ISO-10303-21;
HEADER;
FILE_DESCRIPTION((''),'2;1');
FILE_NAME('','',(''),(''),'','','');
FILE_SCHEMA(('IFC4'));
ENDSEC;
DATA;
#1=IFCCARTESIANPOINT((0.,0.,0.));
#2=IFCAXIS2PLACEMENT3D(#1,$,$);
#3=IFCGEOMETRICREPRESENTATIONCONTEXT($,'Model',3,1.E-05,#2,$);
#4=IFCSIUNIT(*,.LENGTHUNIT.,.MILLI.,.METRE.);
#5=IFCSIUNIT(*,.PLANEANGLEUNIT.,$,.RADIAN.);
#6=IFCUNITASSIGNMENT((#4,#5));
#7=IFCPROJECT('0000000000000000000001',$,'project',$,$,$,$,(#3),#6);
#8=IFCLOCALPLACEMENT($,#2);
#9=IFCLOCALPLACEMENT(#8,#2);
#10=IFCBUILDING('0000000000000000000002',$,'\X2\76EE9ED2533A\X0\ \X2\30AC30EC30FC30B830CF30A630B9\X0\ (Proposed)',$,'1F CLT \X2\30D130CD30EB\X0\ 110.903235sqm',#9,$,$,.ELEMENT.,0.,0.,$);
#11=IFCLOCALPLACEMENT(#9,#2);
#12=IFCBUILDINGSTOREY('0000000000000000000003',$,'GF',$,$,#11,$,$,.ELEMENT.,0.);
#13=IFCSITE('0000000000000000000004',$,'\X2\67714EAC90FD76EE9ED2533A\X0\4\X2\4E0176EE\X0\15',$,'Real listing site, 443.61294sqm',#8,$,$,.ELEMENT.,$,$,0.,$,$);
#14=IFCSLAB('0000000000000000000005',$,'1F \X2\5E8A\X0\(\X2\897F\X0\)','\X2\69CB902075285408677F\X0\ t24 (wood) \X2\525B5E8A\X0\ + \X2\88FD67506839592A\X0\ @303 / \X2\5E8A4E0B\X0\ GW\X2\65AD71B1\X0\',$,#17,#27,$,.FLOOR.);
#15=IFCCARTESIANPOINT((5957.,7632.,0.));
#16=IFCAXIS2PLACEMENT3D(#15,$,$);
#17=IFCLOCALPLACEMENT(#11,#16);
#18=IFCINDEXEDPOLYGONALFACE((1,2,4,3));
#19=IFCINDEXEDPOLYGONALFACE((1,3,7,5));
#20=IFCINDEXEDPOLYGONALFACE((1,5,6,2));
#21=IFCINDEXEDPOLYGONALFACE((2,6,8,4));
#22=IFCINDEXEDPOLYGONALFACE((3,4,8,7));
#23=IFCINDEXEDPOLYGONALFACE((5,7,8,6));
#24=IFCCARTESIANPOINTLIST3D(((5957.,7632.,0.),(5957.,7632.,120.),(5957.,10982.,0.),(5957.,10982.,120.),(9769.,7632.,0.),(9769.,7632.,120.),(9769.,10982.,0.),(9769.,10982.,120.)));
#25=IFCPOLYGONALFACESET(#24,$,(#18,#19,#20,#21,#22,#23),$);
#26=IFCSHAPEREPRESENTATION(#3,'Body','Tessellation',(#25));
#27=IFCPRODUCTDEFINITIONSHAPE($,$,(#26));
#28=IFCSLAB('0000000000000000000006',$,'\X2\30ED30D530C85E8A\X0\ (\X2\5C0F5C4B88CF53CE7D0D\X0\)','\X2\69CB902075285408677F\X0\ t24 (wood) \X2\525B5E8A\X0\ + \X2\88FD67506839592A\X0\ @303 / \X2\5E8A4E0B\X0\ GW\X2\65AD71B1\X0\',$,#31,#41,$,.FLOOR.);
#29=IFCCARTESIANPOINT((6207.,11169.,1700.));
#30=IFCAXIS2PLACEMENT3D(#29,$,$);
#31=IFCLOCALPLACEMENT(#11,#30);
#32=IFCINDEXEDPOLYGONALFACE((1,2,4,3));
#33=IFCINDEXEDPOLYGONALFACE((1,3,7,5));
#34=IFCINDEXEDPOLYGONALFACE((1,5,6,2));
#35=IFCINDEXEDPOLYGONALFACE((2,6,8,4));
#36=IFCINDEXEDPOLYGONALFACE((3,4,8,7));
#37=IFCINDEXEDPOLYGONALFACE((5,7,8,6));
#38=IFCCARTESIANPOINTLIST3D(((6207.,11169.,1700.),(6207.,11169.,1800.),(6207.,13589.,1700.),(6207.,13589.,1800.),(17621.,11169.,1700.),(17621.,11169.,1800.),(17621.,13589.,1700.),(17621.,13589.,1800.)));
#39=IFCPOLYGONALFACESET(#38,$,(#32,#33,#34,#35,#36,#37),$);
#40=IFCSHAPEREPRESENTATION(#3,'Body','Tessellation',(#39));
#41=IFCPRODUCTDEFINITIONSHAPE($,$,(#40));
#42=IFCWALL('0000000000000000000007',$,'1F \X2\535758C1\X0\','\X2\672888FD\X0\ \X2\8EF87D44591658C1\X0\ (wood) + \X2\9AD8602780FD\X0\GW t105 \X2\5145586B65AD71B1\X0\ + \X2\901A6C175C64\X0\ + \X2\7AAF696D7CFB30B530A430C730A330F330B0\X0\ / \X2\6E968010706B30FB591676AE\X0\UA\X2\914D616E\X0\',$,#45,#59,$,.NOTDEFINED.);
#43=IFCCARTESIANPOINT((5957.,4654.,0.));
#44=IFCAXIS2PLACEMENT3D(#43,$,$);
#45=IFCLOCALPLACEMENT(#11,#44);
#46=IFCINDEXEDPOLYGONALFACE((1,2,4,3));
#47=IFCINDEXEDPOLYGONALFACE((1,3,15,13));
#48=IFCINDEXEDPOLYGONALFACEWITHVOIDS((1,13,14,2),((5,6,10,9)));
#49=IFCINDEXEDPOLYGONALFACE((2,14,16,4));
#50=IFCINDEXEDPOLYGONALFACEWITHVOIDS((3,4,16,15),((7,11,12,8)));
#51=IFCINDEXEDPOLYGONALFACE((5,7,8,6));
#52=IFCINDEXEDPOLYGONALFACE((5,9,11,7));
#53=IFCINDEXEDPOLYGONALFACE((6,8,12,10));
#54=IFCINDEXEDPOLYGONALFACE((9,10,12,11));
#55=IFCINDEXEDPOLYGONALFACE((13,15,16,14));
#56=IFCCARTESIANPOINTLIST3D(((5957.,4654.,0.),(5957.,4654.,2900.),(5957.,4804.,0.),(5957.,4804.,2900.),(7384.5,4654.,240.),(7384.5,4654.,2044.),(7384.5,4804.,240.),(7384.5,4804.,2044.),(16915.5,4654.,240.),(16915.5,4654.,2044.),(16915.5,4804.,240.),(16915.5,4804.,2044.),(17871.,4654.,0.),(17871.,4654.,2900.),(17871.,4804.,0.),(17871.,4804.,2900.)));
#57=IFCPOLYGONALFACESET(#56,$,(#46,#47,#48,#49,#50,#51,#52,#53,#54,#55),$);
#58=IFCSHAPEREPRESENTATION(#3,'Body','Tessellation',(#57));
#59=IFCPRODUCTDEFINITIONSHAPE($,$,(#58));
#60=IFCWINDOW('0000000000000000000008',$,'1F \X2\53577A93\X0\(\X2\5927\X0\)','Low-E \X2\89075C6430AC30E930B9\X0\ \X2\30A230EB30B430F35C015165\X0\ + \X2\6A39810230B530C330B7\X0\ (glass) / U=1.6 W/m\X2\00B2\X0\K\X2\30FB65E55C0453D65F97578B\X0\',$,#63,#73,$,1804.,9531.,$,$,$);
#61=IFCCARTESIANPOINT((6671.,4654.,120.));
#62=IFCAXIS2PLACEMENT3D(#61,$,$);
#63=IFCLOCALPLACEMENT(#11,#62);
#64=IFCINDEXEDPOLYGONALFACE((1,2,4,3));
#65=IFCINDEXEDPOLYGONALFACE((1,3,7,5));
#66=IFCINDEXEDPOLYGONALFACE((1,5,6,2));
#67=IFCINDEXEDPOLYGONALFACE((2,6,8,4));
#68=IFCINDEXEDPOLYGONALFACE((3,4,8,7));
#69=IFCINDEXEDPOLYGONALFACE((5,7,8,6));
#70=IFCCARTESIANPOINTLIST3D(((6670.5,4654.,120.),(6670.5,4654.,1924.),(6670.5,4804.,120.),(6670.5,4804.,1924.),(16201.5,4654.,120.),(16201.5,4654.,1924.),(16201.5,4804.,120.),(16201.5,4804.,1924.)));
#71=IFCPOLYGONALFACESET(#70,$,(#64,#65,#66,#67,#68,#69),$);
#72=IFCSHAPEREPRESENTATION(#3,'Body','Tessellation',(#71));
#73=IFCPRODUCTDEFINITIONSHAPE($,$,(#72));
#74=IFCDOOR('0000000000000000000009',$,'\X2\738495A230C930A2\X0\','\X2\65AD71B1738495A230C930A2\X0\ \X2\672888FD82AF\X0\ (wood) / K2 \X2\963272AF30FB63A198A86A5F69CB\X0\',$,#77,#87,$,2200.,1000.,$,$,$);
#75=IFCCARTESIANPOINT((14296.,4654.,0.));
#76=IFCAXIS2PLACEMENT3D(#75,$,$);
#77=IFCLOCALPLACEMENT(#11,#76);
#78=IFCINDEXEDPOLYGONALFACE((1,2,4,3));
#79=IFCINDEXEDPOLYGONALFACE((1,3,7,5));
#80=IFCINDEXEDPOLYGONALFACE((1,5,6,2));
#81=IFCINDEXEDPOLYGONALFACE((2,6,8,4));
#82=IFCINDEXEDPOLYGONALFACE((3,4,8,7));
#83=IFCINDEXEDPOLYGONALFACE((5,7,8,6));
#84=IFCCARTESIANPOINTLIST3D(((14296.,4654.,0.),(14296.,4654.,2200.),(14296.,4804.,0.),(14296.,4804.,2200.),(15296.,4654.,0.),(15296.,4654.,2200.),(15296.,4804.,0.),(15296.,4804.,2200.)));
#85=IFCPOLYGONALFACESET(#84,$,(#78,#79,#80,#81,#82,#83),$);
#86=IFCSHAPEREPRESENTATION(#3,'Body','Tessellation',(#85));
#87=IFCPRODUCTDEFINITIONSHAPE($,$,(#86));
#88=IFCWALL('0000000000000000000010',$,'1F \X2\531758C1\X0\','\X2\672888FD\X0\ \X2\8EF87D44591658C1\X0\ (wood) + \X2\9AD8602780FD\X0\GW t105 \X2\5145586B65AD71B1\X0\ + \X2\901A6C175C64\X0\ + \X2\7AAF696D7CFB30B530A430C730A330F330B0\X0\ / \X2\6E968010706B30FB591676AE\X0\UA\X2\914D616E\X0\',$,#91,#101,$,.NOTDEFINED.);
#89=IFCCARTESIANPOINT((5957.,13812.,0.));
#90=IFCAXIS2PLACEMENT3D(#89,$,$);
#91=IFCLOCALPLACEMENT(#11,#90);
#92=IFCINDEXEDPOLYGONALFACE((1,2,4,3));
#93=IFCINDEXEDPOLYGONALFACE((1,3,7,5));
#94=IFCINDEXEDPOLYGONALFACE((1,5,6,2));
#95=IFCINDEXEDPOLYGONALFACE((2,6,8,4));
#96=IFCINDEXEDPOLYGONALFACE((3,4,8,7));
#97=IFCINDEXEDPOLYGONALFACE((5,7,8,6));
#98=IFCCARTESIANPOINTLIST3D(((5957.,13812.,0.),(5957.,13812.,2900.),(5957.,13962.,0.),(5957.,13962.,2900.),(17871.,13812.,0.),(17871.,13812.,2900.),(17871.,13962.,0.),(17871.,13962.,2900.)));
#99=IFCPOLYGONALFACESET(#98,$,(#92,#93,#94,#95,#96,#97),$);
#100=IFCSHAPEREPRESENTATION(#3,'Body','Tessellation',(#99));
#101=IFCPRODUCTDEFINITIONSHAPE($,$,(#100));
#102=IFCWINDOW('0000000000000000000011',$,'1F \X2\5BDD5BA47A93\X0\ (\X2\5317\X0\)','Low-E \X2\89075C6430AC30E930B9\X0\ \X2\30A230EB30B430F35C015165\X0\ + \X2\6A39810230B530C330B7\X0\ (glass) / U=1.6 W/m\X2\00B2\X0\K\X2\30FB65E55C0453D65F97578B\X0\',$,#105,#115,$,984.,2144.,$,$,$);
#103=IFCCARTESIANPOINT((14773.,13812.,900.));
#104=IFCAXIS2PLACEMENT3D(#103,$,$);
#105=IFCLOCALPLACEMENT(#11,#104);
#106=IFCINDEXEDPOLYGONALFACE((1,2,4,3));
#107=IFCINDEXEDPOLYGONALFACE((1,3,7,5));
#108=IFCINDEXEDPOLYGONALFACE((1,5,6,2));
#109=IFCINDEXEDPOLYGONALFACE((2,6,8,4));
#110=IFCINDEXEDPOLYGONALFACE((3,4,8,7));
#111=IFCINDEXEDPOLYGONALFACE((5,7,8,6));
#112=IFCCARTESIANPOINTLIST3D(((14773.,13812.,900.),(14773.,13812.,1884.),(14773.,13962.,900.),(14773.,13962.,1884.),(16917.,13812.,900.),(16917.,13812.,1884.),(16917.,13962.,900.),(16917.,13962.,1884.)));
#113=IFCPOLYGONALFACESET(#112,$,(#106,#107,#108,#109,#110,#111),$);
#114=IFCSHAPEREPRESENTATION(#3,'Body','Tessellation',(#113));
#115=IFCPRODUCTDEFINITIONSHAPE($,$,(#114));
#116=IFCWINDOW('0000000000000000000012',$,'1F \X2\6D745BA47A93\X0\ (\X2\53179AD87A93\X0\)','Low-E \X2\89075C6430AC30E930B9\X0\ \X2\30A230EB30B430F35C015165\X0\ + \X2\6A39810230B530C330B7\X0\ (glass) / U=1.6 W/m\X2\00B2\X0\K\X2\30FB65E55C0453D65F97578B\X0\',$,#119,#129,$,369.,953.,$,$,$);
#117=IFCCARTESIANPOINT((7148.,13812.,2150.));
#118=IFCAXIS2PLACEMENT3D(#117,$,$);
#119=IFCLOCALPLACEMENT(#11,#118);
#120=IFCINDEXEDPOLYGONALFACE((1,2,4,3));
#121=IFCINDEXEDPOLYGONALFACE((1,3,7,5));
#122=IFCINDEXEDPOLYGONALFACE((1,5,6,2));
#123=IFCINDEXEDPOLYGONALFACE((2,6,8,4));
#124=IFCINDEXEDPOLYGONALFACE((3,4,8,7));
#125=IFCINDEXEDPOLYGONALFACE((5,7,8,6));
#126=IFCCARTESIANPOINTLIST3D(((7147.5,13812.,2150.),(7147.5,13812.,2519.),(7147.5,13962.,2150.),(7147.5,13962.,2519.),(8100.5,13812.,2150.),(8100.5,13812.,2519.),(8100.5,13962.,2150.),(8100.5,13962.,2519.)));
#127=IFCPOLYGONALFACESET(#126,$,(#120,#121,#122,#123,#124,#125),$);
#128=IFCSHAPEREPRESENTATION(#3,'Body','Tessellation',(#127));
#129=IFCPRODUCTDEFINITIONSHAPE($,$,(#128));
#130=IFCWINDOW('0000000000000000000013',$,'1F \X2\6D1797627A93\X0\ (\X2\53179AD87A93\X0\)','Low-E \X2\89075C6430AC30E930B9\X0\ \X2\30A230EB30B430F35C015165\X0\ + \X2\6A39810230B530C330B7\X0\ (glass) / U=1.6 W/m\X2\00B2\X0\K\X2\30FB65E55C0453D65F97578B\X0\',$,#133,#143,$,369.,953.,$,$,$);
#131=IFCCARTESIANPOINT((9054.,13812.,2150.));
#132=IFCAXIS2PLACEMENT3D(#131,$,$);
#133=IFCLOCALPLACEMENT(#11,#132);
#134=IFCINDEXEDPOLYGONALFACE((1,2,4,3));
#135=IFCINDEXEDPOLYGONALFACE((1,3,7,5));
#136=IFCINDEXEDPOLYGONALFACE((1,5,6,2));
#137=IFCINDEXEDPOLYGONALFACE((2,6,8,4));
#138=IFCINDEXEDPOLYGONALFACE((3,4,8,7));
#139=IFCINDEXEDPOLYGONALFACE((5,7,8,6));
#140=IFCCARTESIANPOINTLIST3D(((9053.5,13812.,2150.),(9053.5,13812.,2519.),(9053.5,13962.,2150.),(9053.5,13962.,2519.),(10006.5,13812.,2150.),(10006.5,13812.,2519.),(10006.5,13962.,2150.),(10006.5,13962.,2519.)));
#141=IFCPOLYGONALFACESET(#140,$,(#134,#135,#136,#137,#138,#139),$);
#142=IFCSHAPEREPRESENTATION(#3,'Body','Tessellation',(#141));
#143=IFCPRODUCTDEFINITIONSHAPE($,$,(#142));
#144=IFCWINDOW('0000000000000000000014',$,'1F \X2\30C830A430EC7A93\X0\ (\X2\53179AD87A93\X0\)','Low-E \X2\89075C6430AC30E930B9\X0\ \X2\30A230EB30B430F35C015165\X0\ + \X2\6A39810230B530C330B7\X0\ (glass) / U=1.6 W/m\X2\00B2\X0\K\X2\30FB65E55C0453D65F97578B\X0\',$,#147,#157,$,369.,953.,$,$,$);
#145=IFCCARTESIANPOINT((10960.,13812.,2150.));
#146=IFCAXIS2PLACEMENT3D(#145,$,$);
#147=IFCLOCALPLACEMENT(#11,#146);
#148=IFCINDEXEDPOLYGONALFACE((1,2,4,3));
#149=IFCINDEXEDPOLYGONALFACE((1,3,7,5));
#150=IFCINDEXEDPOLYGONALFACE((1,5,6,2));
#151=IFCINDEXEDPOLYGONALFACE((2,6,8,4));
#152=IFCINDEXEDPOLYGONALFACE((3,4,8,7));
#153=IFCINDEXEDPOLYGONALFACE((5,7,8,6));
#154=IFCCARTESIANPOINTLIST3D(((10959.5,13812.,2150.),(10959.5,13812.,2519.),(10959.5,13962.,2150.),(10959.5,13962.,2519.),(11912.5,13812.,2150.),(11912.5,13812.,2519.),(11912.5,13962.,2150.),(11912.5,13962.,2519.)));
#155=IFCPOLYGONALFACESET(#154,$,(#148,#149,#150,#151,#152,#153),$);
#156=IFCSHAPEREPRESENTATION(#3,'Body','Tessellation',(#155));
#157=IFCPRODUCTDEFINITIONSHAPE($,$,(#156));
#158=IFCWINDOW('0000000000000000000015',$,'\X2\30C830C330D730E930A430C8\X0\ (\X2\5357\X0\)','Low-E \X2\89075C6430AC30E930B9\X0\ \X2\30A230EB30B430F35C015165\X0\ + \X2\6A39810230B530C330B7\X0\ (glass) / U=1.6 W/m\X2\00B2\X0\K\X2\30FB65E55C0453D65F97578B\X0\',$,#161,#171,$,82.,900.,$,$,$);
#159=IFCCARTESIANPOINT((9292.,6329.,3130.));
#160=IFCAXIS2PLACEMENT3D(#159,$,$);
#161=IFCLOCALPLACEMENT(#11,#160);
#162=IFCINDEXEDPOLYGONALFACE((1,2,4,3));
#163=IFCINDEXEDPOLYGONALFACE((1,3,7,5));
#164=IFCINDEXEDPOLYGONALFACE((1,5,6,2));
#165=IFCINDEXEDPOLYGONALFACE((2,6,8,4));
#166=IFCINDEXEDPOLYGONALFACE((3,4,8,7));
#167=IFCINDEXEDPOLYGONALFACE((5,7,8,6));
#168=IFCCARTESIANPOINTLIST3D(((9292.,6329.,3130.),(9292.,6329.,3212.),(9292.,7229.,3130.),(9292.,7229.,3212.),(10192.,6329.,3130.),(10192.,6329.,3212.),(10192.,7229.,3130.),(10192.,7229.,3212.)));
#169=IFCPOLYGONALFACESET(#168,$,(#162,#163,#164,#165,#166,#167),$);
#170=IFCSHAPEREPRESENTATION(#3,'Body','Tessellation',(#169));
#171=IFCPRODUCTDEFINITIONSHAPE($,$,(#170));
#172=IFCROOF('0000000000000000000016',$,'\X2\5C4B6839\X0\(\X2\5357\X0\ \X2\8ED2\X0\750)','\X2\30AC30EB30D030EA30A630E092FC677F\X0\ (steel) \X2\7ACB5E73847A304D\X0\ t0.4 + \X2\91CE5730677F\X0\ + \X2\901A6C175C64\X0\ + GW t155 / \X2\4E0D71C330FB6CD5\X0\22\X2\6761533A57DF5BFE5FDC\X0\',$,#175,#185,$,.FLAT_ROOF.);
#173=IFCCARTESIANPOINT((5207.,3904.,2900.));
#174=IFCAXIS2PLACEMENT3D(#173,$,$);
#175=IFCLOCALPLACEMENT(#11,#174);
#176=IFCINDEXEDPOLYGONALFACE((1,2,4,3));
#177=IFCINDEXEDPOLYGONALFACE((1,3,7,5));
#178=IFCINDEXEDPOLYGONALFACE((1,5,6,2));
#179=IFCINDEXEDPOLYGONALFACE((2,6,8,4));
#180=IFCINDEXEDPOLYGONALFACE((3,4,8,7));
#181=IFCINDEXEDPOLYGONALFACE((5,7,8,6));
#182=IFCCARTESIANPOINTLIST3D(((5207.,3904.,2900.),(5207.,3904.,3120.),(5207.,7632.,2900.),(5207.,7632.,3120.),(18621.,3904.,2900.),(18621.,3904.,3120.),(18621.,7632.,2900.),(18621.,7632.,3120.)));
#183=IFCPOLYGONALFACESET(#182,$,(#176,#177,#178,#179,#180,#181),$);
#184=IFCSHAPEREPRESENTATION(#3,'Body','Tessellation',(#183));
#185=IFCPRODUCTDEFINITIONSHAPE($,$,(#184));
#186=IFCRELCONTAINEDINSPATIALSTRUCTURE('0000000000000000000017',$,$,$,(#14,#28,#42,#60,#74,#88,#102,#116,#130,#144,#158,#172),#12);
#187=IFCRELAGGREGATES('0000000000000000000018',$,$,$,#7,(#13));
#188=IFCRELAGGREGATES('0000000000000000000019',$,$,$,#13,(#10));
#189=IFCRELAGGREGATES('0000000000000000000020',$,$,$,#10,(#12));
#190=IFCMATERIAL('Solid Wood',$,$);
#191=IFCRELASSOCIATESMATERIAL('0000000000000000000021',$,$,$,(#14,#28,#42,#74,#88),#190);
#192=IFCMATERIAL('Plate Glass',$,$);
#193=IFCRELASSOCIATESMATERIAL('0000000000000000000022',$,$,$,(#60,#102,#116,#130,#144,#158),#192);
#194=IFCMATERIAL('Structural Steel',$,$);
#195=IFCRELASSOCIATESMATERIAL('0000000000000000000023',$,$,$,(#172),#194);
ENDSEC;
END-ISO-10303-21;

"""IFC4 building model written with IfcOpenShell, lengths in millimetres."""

from ifc_helpers import new_model, si_unit, frame, frame_2d, origin, place, context, project, spatial, rectangle, extrude, material, element, fill, save


model = new_model("IFC4")

# Units and contexts
model_context = context("Model", 3, precision=1e-05, world=origin())
ifc_project = project(units=[si_unit("LENGTHUNIT", "METRE", prefix="MILLI"), si_unit("PLANEANGLEUNIT", "RADIAN")], contexts=[model_context])

# Site, building, storey
site_placement = place(None, origin())
site = spatial("IfcSite", under=ifc_project, at=site_placement, Name="東京都目黒区4丁目15", ObjectType="Real listing site, 443.61294sqm", CompositionType="ELEMENT", RefElevation=0.0)
building_placement = place(site_placement, origin())
building = spatial("IfcBuilding", under=site, at=building_placement, Name="目黒区 ガレージハウス (Proposed)", ObjectType="1F CLT パネル 110.903235sqm", CompositionType="ELEMENT", ElevationOfRefHeight=0.0, ElevationOfTerrain=0.0)
storey_placement = place(building_placement, origin())
storey = spatial("IfcBuildingStorey", under=building, at=storey_placement, Name="GF", CompositionType="ELEMENT", Elevation=0.0)

# Slabs
ifc_material_1 = material(Name="Solid Wood")
slab_1_placement = place(storey_placement, frame((5957.0, 7632.0, 0.0)))
element("IfcSlab", 1, at=slab_1_placement, inside=storey, material=ifc_material_1, Name="1F 床(西)", Description="構造用合板 t24 (wood) 剛床 + 製材根太 @303 / 床下 GW断熱", PredefinedType="FLOOR", context=model_context, shape_type="SweptSolid", body=[
    extrude(rectangle(XDim=3812.0, YDim=3350.0, at=frame_2d((1906.0, 1675.0))), frame((5957.0, 7632.0, 0.0)), (0.0, 0.0, 1.0), 120.0),
])
slab_2_placement = place(storey_placement, frame((6207.0, 11169.0, 1700.0)))
element("IfcSlab", 2, at=slab_2_placement, inside=storey, material=ifc_material_1, Name="ロフト床 (小屋裏収納)", Description="構造用合板 t24 (wood) 剛床 + 製材根太 @303 / 床下 GW断熱", PredefinedType="FLOOR", context=model_context, shape_type="SweptSolid", body=[
    extrude(rectangle(XDim=11414.0, YDim=2420.0, at=frame_2d((5707.0, 1210.0))), frame((6207.0, 11169.0, 1700.0)), (0.0, 0.0, 1.0), 100.0),
])

# Wall, openings, window, door
wall_1_placement = place(storey_placement, frame((5957.0, 4654.0, 0.0)))
wall_1 = element("IfcWall", 3, at=wall_1_placement, inside=storey, material=ifc_material_1, Name="1F 南壁", Description="木製 軸組外壁 (wood) + 高性能GW t105 充填断熱 + 通気層 + 窯業系サイディング / 準耐火・外皮UA配慮", PredefinedType="NOTDEFINED", context=model_context, shape_type="SweptSolid", body=[
    extrude(rectangle(XDim=11914.0, YDim=150.0, at=frame_2d((5957.0, 75.0))), frame((5957.0, 4654.0, 0.0)), (0.0, 0.0, 1.0), 2900.0),
])
opening_1_placement = place(storey_placement, frame((6671.0, 4654.0, 120.0)))
opening_1 = element("IfcOpeningElement", 4, at=opening_1_placement, cuts=wall_1, PredefinedType="NOTDEFINED", context=model_context, shape_type="SweptSolid", body=[
    extrude(rectangle(XDim=9531.0, YDim=150.0, at=frame_2d((4765.0, 75.0))), frame((6671.0, 4654.0, 120.0)), (0.0, 0.0, 1.0), 1804.0),
])
opening_2_placement = place(storey_placement, frame((14296.0, 4654.0, 0.0)))
opening_2 = element("IfcOpeningElement", 5, at=opening_2_placement, cuts=wall_1, PredefinedType="NOTDEFINED", context=model_context, shape_type="SweptSolid", body=[
    extrude(rectangle(XDim=1000.0, YDim=150.0, at=frame_2d((500.0, 75.0))), frame((14296.0, 4654.0, 0.0)), (0.0, 0.0, 1.0), 2200.0),
])
ifc_material_2 = material(Name="Plate Glass")
window_1_placement = place(storey_placement, frame((6671.0, 4654.0, 120.0)))
window_1 = element("IfcWindow", 6, at=window_1_placement, inside=storey, material=ifc_material_2, Name="1F 南窓(大)", Description="Low-E 複層ガラス アルゴン封入 + 樹脂サッシ (glass) / U=1.6 W/m²K・日射取得型", OverallHeight=1804.0, OverallWidth=9531.0, context=model_context, shape_type="SweptSolid", body=[
    extrude(rectangle(XDim=9531.0, YDim=150.0, at=frame_2d((4765.0, 75.0))), frame((6671.0, 4654.0, 120.0)), (0.0, 0.0, 1.0), 1804.0),
])
fill(opening_1, window_1)
door_1_placement = place(storey_placement, frame((14296.0, 4654.0, 0.0)))
door_1 = element("IfcDoor", 7, at=door_1_placement, inside=storey, material=ifc_material_1, Name="玄関ドア", Description="断熱玄関ドア 木製芯 (wood) / K2 防犯・採風機構", OverallHeight=2200.0, OverallWidth=1000.0, context=model_context, shape_type="SweptSolid", body=[
    extrude(rectangle(XDim=1000.0, YDim=150.0, at=frame_2d((500.0, 75.0))), frame((14296.0, 4654.0, 0.0)), (0.0, 0.0, 1.0), 2200.0),
])
fill(opening_2, door_1)

# Wall, openings, windows
wall_2_placement = place(storey_placement, frame((5957.0, 13812.0, 0.0)))
wall_2 = element("IfcWall", 8, at=wall_2_placement, inside=storey, material=ifc_material_1, Name="1F 北壁", Description="木製 軸組外壁 (wood) + 高性能GW t105 充填断熱 + 通気層 + 窯業系サイディング / 準耐火・外皮UA配慮", PredefinedType="NOTDEFINED", context=model_context, shape_type="SweptSolid", body=[
    extrude(rectangle(XDim=11914.0, YDim=150.0, at=frame_2d((5957.0, 75.0))), frame((5957.0, 13812.0, 0.0)), (0.0, 0.0, 1.0), 2900.0),
])
opening_3_placement = place(storey_placement, frame((14773.0, 13812.0, 900.0)))
opening_3 = element("IfcOpeningElement", 9, at=opening_3_placement, cuts=wall_2, PredefinedType="NOTDEFINED", context=model_context, shape_type="SweptSolid", body=[
    extrude(rectangle(XDim=2144.0, YDim=150.0, at=frame_2d((1072.0, 75.0))), frame((14773.0, 13812.0, 900.0)), (0.0, 0.0, 1.0), 984.0),
])
opening_4_placement = place(storey_placement, frame((7148.0, 13812.0, 2150.0)))
opening_4 = element("IfcOpeningElement", 10, at=opening_4_placement, cuts=wall_2, PredefinedType="NOTDEFINED", context=model_context, shape_type="SweptSolid", body=[
    extrude(rectangle(XDim=953.0, YDim=150.0, at=frame_2d((476.0, 75.0))), frame((7148.0, 13812.0, 2150.0)), (0.0, 0.0, 1.0), 369.0),
])
opening_5_placement = place(storey_placement, frame((9054.0, 13812.0, 2150.0)))
opening_5 = element("IfcOpeningElement", 11, at=opening_5_placement, cuts=wall_2, PredefinedType="NOTDEFINED", context=model_context, shape_type="SweptSolid", body=[
    extrude(rectangle(XDim=953.0, YDim=150.0, at=frame_2d((476.0, 75.0))), frame((9054.0, 13812.0, 2150.0)), (0.0, 0.0, 1.0), 369.0),
])
opening_6_placement = place(storey_placement, frame((10960.0, 13812.0, 2150.0)))
opening_6 = element("IfcOpeningElement", 12, at=opening_6_placement, cuts=wall_2, PredefinedType="NOTDEFINED", context=model_context, shape_type="SweptSolid", body=[
    extrude(rectangle(XDim=953.0, YDim=150.0, at=frame_2d((476.0, 75.0))), frame((10960.0, 13812.0, 2150.0)), (0.0, 0.0, 1.0), 369.0),
])
window_2_placement = place(storey_placement, frame((14773.0, 13812.0, 900.0)))
window_2 = element("IfcWindow", 13, at=window_2_placement, inside=storey, material=ifc_material_2, Name="1F 寝室窓 (北)", Description="Low-E 複層ガラス アルゴン封入 + 樹脂サッシ (glass) / U=1.6 W/m²K・日射取得型", OverallHeight=984.0, OverallWidth=2144.0, context=model_context, shape_type="SweptSolid", body=[
    extrude(rectangle(XDim=2144.0, YDim=150.0, at=frame_2d((1072.0, 75.0))), frame((14773.0, 13812.0, 900.0)), (0.0, 0.0, 1.0), 984.0),
])
fill(opening_3, window_2)
window_3_placement = place(storey_placement, frame((7148.0, 13812.0, 2150.0)))
window_3 = element("IfcWindow", 14, at=window_3_placement, inside=storey, material=ifc_material_2, Name="1F 浴室窓 (北高窓)", Description="Low-E 複層ガラス アルゴン封入 + 樹脂サッシ (glass) / U=1.6 W/m²K・日射取得型", OverallHeight=369.0, OverallWidth=953.0, context=model_context, shape_type="SweptSolid", body=[
    extrude(rectangle(XDim=953.0, YDim=150.0, at=frame_2d((476.0, 75.0))), frame((7148.0, 13812.0, 2150.0)), (0.0, 0.0, 1.0), 369.0),
])
fill(opening_4, window_3)
window_4_placement = place(storey_placement, frame((9054.0, 13812.0, 2150.0)))
window_4 = element("IfcWindow", 15, at=window_4_placement, inside=storey, material=ifc_material_2, Name="1F 洗面窓 (北高窓)", Description="Low-E 複層ガラス アルゴン封入 + 樹脂サッシ (glass) / U=1.6 W/m²K・日射取得型", OverallHeight=369.0, OverallWidth=953.0, context=model_context, shape_type="SweptSolid", body=[
    extrude(rectangle(XDim=953.0, YDim=150.0, at=frame_2d((476.0, 75.0))), frame((9054.0, 13812.0, 2150.0)), (0.0, 0.0, 1.0), 369.0),
])
fill(opening_5, window_4)
window_5_placement = place(storey_placement, frame((10960.0, 13812.0, 2150.0)))
window_5 = element("IfcWindow", 16, at=window_5_placement, inside=storey, material=ifc_material_2, Name="1F トイレ窓 (北高窓)", Description="Low-E 複層ガラス アルゴン封入 + 樹脂サッシ (glass) / U=1.6 W/m²K・日射取得型", OverallHeight=369.0, OverallWidth=953.0, context=model_context, shape_type="SweptSolid", body=[
    extrude(rectangle(XDim=953.0, YDim=150.0, at=frame_2d((476.0, 75.0))), frame((10960.0, 13812.0, 2150.0)), (0.0, 0.0, 1.0), 369.0),
])
fill(opening_6, window_5)

# Window
window_6_placement = place(storey_placement, frame((9292.0, 6329.0, 3130.0)))
element("IfcWindow", 17, at=window_6_placement, inside=storey, material=ifc_material_2, Name="トップライト (南)", Description="Low-E 複層ガラス アルゴン封入 + 樹脂サッシ (glass) / U=1.6 W/m²K・日射取得型", OverallHeight=82.0, OverallWidth=900.0, context=model_context, shape_type="SweptSolid", body=[
    extrude(rectangle(XDim=900.0, YDim=900.0, at=frame_2d((450.0, 450.0))), frame((9292.0, 6329.0, 3130.0)), (0.0, 0.0, 1.0), 82.0),
])

# Roof
ifc_material_3 = material(Name="Structural Steel")
roof_1_placement = place(storey_placement, frame((5207.0, 3904.0, 2900.0)))
element("IfcRoof", 18, at=roof_1_placement, inside=storey, material=ifc_material_3, Name="屋根(南 軒750)", Description="ガルバリウム鋼板 (steel) 立平葺き t0.4 + 野地板 + 通気層 + GW t155 / 不燃・法22条区域対応", PredefinedType="FLAT_ROOF", context=model_context, shape_type="SweptSolid", body=[
    extrude(rectangle(XDim=13414.0, YDim=3728.0, at=frame_2d((6707.0, 1864.0))), frame((5207.0, 3904.0, 2900.0)), (0.0, 0.0, 1.0), 220.0),
])

save(model, "model.ifc")
